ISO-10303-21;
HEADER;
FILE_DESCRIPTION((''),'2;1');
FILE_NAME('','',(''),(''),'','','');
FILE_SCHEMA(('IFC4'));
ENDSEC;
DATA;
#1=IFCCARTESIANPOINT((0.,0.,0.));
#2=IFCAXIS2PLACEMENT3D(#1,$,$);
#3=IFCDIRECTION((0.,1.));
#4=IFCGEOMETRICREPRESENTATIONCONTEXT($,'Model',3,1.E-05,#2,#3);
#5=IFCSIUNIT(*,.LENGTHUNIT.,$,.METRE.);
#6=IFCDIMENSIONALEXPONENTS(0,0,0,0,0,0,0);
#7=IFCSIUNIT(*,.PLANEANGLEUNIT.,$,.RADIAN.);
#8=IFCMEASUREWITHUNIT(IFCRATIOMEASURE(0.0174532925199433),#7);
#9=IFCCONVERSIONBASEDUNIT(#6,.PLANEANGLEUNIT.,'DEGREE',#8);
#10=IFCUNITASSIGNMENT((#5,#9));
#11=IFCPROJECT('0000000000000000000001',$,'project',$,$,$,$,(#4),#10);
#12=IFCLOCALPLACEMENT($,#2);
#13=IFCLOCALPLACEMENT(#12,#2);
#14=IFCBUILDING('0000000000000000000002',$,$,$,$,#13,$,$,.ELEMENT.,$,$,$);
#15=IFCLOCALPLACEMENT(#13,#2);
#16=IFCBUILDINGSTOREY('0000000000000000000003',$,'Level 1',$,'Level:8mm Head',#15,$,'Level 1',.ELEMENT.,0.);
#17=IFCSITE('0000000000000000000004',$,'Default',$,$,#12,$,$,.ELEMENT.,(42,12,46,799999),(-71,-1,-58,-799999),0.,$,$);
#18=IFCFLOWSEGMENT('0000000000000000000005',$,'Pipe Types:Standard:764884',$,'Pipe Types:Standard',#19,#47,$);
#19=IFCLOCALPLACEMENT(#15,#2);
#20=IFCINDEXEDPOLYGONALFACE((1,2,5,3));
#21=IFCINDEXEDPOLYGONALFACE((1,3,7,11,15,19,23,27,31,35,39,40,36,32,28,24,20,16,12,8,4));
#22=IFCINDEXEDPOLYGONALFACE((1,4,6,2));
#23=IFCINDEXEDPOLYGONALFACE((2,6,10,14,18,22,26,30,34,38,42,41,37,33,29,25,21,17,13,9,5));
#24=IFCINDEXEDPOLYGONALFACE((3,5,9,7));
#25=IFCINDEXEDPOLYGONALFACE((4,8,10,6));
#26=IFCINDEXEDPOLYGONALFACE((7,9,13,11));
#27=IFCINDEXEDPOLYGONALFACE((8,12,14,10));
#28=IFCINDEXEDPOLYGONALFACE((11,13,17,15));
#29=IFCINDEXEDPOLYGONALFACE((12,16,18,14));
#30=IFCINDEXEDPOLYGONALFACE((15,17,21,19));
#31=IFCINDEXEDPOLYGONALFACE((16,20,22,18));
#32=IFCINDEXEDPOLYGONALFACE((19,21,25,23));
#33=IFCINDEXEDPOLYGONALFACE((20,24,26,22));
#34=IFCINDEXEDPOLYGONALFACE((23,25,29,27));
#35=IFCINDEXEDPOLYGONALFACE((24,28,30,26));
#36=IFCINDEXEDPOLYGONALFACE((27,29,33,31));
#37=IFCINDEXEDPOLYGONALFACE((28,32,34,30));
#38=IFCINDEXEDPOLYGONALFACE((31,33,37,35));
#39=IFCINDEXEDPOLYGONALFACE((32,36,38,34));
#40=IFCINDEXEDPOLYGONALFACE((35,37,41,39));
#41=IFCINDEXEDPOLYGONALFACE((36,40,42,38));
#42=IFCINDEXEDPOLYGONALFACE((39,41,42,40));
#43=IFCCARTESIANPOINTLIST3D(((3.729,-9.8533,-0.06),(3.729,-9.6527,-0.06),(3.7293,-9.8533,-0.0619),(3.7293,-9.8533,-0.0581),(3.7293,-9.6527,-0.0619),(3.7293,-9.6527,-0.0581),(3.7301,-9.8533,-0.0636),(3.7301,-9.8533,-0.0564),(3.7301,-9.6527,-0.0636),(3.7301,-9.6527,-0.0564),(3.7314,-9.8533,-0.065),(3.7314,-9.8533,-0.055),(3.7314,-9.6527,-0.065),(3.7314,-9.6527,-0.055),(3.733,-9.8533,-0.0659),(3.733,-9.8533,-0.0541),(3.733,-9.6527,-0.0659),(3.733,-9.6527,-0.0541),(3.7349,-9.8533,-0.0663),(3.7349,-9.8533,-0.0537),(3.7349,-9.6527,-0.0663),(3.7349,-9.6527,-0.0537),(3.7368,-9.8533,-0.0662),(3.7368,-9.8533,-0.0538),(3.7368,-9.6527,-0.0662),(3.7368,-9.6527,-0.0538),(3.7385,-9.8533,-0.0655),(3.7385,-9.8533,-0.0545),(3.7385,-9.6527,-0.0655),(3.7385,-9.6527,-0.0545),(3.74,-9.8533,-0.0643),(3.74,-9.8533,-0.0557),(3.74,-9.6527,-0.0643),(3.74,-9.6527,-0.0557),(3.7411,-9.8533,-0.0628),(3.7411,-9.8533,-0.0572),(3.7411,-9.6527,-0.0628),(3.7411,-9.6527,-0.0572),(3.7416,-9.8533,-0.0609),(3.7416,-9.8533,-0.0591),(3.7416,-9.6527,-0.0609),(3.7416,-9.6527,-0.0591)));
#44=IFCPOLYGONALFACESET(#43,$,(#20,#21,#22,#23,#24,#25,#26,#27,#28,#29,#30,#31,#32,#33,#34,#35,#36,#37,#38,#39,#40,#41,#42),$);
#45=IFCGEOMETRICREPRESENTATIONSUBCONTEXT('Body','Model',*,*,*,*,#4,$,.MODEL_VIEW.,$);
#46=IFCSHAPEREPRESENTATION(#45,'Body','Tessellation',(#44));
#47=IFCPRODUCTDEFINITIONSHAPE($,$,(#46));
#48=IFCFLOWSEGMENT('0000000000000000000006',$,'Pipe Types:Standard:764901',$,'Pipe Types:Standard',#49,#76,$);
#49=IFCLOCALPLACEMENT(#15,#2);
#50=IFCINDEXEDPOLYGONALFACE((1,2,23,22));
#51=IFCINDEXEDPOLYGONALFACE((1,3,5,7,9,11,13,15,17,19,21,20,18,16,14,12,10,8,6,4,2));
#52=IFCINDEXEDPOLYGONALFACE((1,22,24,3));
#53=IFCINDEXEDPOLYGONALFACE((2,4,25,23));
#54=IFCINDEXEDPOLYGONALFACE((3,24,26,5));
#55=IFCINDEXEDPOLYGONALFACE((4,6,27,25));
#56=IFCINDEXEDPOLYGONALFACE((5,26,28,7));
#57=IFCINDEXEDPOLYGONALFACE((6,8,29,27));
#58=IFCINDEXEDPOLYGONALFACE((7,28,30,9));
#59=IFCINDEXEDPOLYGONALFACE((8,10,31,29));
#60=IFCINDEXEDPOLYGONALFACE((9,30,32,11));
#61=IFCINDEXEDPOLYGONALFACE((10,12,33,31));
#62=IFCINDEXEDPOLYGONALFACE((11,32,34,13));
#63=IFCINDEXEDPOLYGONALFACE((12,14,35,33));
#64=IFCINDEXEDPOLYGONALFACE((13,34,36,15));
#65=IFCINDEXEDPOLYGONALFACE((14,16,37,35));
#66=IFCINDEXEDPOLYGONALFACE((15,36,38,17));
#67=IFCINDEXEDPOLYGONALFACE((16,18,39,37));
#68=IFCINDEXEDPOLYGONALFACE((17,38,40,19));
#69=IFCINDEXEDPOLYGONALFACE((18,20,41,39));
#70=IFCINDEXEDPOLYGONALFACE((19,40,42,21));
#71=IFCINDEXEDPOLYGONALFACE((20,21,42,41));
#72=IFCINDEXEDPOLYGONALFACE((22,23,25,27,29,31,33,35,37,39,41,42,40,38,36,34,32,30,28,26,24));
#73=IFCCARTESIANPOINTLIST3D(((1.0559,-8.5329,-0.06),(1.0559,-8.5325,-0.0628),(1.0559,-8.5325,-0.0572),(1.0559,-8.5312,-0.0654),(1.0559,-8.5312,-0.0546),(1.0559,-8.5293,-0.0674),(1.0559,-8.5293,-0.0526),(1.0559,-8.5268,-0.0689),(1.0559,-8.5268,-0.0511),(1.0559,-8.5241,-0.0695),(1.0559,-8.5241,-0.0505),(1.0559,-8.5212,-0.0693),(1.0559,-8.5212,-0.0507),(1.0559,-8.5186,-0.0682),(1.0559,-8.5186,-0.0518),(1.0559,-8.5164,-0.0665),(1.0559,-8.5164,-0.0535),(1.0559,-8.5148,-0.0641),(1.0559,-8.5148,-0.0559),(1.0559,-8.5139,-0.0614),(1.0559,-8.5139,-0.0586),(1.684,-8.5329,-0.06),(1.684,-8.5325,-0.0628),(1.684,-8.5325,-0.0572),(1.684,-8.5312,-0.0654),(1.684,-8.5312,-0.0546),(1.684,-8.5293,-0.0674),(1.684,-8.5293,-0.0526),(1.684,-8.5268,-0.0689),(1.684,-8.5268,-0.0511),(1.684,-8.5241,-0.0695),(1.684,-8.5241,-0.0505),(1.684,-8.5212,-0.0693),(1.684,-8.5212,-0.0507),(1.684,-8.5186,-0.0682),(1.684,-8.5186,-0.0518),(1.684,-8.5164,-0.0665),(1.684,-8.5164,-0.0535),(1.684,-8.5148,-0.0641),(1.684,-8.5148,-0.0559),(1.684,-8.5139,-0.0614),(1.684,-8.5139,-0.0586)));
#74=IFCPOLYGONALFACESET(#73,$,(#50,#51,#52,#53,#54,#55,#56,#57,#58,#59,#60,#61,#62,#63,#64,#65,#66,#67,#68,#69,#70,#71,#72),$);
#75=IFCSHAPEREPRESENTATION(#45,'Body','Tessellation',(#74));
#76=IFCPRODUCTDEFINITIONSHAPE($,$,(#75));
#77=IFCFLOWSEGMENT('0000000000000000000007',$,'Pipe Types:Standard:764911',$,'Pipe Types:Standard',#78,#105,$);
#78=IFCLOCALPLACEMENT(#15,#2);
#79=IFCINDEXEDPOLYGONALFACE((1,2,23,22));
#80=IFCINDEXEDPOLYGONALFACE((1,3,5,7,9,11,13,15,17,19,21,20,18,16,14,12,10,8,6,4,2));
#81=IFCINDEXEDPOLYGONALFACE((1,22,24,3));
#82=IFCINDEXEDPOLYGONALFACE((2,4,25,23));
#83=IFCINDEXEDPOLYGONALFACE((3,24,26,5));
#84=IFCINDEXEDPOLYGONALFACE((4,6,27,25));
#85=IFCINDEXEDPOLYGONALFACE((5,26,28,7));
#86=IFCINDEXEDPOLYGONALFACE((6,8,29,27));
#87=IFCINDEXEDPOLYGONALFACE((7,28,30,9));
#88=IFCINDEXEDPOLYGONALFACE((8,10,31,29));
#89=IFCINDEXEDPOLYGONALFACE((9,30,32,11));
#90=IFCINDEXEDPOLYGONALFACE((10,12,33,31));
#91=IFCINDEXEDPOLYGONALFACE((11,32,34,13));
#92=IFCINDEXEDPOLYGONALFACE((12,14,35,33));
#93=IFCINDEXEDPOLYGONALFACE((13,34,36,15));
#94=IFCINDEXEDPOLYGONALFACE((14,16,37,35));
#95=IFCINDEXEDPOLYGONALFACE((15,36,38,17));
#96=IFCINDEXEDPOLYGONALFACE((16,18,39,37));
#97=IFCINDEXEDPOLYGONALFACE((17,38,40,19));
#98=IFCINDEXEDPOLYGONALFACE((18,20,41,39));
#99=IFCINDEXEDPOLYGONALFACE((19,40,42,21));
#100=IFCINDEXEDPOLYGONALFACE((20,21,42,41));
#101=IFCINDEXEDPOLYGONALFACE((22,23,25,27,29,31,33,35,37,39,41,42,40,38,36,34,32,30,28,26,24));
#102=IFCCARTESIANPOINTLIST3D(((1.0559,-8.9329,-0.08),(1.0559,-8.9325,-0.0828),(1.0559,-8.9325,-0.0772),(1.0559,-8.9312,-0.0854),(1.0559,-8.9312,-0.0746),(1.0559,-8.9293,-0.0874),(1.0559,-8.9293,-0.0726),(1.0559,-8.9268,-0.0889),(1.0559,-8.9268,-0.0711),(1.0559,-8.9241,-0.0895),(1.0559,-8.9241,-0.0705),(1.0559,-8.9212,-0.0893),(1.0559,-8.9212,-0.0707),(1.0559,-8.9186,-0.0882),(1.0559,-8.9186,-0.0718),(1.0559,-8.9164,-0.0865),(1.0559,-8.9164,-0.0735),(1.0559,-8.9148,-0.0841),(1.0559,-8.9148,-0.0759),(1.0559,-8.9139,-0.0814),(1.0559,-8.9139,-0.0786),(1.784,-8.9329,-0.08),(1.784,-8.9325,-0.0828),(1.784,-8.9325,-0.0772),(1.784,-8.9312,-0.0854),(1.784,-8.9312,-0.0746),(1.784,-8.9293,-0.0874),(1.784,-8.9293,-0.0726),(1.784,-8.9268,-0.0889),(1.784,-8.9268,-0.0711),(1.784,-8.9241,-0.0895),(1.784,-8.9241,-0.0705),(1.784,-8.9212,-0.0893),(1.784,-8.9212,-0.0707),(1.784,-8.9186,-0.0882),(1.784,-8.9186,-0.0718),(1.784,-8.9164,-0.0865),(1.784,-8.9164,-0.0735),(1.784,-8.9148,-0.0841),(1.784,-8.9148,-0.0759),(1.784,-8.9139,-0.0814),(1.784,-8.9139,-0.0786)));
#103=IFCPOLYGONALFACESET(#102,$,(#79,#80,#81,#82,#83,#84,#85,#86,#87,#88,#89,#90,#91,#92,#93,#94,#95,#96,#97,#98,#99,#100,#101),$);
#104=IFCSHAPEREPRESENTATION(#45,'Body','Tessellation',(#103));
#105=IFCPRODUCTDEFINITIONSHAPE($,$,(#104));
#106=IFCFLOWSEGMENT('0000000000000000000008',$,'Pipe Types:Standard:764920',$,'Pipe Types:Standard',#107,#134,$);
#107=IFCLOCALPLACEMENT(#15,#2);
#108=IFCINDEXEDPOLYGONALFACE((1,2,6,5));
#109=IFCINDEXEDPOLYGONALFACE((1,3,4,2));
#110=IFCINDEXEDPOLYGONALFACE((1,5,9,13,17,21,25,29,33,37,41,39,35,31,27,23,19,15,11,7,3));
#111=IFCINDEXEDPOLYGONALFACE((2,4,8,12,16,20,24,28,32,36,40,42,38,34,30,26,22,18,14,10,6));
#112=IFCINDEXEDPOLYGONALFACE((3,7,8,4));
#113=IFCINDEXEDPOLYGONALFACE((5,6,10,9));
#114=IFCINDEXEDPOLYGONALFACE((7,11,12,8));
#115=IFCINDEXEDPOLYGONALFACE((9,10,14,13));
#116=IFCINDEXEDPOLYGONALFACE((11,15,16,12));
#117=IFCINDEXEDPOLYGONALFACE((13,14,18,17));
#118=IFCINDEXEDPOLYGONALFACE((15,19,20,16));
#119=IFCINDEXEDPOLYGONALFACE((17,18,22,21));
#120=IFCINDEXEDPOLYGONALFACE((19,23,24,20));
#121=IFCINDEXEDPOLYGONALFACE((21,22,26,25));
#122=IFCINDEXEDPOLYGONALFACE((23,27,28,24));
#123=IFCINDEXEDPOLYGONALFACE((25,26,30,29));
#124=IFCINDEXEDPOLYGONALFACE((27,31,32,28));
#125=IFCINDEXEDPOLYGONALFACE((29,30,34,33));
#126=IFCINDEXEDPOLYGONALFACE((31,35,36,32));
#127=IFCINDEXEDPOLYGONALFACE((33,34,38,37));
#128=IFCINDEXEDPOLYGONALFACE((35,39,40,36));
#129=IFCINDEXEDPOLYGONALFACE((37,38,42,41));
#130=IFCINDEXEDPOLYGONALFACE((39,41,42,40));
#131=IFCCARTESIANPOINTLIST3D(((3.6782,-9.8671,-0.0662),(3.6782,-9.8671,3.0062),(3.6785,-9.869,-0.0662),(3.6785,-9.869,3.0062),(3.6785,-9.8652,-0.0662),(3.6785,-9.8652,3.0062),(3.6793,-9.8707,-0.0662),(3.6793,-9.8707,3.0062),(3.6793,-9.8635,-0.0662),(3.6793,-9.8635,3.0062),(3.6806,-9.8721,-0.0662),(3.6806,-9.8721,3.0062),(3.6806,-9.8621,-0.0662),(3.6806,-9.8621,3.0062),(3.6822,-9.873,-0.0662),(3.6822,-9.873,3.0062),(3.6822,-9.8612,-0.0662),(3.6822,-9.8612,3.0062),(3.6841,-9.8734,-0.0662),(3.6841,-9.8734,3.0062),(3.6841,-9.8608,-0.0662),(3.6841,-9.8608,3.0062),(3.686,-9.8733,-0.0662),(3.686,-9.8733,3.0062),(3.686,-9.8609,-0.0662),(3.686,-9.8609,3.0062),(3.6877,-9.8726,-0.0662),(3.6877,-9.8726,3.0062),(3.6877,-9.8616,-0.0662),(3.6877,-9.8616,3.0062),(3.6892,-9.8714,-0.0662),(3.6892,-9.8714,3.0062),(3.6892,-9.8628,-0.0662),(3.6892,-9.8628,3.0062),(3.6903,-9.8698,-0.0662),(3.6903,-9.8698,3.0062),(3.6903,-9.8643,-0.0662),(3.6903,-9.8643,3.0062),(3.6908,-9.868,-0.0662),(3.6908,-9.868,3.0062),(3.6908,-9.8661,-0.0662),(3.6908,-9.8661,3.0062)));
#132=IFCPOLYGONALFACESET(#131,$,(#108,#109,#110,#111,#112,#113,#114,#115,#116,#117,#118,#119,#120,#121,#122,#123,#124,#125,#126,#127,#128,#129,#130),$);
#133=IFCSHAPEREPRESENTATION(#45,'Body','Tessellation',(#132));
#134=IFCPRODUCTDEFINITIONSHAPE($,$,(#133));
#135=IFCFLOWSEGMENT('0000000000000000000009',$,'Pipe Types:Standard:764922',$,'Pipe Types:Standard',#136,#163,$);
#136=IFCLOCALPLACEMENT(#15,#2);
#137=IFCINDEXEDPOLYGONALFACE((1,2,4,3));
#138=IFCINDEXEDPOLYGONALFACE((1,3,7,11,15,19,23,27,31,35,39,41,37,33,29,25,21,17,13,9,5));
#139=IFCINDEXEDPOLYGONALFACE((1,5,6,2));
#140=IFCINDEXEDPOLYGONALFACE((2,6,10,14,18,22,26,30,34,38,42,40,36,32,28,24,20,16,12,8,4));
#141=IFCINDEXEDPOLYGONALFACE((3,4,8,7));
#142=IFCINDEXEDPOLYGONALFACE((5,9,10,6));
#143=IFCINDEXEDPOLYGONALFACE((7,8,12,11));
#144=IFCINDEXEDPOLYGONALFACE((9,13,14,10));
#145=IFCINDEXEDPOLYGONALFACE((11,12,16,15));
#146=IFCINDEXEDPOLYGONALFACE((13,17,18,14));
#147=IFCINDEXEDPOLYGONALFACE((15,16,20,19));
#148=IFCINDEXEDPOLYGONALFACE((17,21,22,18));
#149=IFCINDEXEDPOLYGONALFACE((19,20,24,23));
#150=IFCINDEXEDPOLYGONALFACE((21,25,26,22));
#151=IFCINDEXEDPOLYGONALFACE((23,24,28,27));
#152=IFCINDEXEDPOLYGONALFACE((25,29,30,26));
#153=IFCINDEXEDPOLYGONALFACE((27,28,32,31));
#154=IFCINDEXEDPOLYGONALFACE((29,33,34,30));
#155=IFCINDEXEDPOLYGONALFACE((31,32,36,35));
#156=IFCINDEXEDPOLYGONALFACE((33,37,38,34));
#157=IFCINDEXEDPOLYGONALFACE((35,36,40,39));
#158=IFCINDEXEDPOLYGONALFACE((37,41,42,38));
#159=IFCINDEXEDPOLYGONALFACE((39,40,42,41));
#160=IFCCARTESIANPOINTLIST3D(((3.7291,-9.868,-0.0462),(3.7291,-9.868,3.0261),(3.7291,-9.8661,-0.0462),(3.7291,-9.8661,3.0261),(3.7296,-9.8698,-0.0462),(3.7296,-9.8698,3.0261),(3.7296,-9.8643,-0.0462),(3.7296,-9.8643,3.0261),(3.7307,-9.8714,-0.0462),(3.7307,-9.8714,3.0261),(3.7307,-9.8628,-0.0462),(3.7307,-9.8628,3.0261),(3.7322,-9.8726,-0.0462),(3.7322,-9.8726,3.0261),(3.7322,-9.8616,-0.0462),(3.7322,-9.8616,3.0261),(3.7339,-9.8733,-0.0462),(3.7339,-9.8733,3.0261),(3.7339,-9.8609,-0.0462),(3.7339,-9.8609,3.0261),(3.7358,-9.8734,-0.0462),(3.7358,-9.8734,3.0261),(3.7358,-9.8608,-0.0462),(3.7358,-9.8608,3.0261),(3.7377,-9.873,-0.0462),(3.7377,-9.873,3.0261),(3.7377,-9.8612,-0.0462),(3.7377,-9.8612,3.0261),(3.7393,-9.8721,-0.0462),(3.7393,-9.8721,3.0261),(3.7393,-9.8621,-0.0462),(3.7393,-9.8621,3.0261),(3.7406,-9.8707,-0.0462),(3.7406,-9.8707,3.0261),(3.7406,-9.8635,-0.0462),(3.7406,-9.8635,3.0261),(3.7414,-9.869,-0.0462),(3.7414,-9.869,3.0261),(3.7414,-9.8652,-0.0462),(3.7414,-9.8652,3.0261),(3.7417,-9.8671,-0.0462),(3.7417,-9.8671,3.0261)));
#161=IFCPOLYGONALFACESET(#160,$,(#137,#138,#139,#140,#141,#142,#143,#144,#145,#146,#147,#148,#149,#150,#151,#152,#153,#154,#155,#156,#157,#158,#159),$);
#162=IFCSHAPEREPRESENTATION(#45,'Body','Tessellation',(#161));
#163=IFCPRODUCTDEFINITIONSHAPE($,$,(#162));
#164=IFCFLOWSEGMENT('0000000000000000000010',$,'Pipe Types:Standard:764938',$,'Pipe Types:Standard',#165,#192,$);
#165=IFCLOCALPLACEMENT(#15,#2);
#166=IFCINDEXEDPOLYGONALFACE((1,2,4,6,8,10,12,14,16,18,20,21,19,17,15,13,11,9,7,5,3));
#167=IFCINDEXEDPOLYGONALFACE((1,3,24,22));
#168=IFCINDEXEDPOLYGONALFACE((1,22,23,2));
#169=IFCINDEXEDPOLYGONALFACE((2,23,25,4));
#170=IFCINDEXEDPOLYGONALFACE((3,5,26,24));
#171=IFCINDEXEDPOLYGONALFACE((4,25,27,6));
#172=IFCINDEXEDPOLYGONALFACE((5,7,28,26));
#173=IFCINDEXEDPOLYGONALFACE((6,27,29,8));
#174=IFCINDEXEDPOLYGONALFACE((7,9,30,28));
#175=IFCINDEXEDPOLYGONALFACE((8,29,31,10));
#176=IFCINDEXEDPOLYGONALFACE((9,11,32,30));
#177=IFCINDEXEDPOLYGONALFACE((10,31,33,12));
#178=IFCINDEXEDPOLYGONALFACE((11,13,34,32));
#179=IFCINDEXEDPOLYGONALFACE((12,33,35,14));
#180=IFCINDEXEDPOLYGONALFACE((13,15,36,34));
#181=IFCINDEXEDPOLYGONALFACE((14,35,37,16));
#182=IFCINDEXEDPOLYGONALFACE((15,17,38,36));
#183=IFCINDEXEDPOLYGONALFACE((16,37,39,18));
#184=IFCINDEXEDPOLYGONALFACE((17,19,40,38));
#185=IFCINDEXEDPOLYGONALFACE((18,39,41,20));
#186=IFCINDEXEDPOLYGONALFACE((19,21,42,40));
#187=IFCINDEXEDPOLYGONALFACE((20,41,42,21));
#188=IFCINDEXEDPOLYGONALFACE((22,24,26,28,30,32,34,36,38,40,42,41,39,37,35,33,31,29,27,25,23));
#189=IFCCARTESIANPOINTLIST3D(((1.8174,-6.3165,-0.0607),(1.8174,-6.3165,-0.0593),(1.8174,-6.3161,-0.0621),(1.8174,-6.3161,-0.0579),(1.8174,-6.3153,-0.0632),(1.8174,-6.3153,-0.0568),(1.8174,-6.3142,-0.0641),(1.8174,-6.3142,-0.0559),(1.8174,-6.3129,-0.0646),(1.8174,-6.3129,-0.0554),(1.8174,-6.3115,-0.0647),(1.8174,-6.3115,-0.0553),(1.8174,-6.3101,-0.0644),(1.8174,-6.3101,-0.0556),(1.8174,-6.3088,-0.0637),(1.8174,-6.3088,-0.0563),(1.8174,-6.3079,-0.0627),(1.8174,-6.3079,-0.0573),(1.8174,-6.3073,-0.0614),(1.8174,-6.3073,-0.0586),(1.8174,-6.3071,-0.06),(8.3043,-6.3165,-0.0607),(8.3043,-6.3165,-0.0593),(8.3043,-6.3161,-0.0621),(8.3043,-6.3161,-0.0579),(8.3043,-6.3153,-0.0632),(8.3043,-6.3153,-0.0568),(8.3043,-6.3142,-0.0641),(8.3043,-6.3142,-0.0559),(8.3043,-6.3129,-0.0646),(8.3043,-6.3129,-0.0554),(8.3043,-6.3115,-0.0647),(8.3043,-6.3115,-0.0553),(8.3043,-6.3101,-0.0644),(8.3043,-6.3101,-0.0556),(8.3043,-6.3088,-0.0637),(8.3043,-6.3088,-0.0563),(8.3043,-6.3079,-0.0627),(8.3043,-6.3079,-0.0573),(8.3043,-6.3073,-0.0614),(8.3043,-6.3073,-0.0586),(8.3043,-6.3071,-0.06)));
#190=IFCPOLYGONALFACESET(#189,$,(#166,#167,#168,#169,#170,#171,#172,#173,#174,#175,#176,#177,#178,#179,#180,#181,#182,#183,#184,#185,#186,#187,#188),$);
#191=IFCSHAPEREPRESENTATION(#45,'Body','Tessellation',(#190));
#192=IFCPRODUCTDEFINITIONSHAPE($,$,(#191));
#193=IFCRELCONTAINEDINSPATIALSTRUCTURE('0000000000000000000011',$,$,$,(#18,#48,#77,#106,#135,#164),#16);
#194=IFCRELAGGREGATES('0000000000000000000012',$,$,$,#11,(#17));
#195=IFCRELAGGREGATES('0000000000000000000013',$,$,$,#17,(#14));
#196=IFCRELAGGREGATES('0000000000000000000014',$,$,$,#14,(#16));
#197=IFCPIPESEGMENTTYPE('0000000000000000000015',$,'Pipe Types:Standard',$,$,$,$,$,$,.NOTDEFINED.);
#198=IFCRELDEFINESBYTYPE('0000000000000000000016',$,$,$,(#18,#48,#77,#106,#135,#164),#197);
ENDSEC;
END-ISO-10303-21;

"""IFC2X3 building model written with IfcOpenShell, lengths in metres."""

from ifc_helpers import new_model, entity, si_unit, converted_unit, direction, frame, frame_2d, origin, origin_2d_with_axis, place, context, subcontext, project, spatial, circle, extrude, type_object, element, save


model = new_model("IFC2X3")

# Units and contexts
model_context = context("Model", 3, precision=1e-05, world=origin(), true_north=direction((0.0, 1.0)))
body_context = subcontext(model_context, "Body", "Model", "MODEL_VIEW")
ifc_project = project(units=[si_unit("LENGTHUNIT", "METRE"), converted_unit("PLANEANGLEUNIT", "DEGREE", entity("IfcRatioMeasure", 0.0174532925199433), si_unit("PLANEANGLEUNIT", "RADIAN"), dimensions=[0, 0, 0, 0, 0, 0, 0])], contexts=[model_context])

# Site, building, storey
site_placement = place(None, origin())
site = spatial("IfcSite", under=ifc_project, at=site_placement, Name="Default", CompositionType="ELEMENT", RefLatitude=(42, 12, 46, 799999), RefLongitude=(-71, -1, -58, -799999), RefElevation=0.0)
building_placement = place(site_placement, origin())
building = spatial("IfcBuilding", under=site, at=building_placement, CompositionType="ELEMENT")
storey_placement = place(building_placement, origin())
storey = spatial("IfcBuildingStorey", under=building, at=storey_placement, Name="Level 1", ObjectType="Level:8mm Head", LongName="Level 1", CompositionType="ELEMENT", Elevation=0.0)

# Flow segments
pipe_segment_type = type_object("IfcPipeSegmentType", Name="Pipe Types:Standard", PredefinedType="NOTDEFINED")
flow_segment_1_placement = place(storey_placement, origin())
element("IfcFlowSegment", 1, at=flow_segment_1_placement, inside=storey, type_object=pipe_segment_type, Name="Pipe Types:Standard:764884", ObjectType="Pipe Types:Standard", context=body_context, shape_type="SweptSolid", body=[
    extrude(circle(Radius=0.0063, at=frame_2d((0.0, 0.0), x_axis=(1.0, 0.0))), frame((3.7353, -9.8533, -0.06), z_axis=(0.0, 1.0, 0.0), x_axis=(-1.0, 0.0, 0.0)), (0.0, 0.0, 1.0), 0.2006),
])
flow_segment_2_placement = place(storey_placement, origin())
element("IfcFlowSegment", 2, at=flow_segment_2_placement, inside=storey, type_object=pipe_segment_type, Name="Pipe Types:Standard:764901", ObjectType="Pipe Types:Standard", context=body_context, shape_type="SweptSolid", body=[
    extrude(circle(Radius=0.0095, at=frame_2d((0.0, 0.0), x_axis=(1.0, 0.0))), frame((1.0559, -8.5234, -0.06), z_axis=(1.0, 0.0, 0.0), x_axis=(0.0, -1.0, 0.0)), (0.0, 0.0, 1.0), 0.6281),
])
flow_segment_3_placement = place(storey_placement, origin())
element("IfcFlowSegment", 3, at=flow_segment_3_placement, inside=storey, type_object=pipe_segment_type, Name="Pipe Types:Standard:764911", ObjectType="Pipe Types:Standard", context=body_context, shape_type="SweptSolid", body=[
    extrude(circle(Radius=0.0095, at=origin_2d_with_axis()), frame((1.0559, -8.9234, -0.08), z_axis=(1.0, 0.0, 0.0), x_axis=(0.0, -1.0, 0.0)), (0.0, 0.0, 1.0), 0.7281),
])
flow_segment_4_placement = place(storey_placement, origin())
element("IfcFlowSegment", 4, at=flow_segment_4_placement, inside=storey, type_object=pipe_segment_type, Name="Pipe Types:Standard:764920", ObjectType="Pipe Types:Standard", context=body_context, shape_type="SweptSolid", body=[
    extrude(circle(Radius=0.0063, at=origin_2d_with_axis()), frame((3.6845, -9.8671, -0.0662), z_axis=(0.0, 0.0, 1.0), x_axis=(-1.0, 0.0, 0.0)), (0.0, 0.0, 1.0), 3.0724),
])
flow_segment_5_placement = place(storey_placement, origin())
element("IfcFlowSegment", 5, at=flow_segment_5_placement, inside=storey, type_object=pipe_segment_type, Name="Pipe Types:Standard:764922", ObjectType="Pipe Types:Standard", context=body_context, shape_type="SweptSolid", body=[
    extrude(circle(Radius=0.0063, at=origin_2d_with_axis()), frame((3.7353, -9.8671, -0.0462)), (0.0, 0.0, 1.0), 3.0723),
])
flow_segment_6_placement = place(storey_placement, origin())
element("IfcFlowSegment", 6, at=flow_segment_6_placement, inside=storey, type_object=pipe_segment_type, Name="Pipe Types:Standard:764938", ObjectType="Pipe Types:Standard", context=body_context, shape_type="SweptSolid", body=[
    extrude(circle(Radius=0.0048, at=frame_2d((0.0, 0.0), x_axis=(1.0, 0.0))), frame((1.8174, -6.3118, -0.06), z_axis=(1.0, 0.0, 0.0), x_axis=(0.0, 1.0, 0.0)), (0.0, 0.0, 1.0), 6.4868),
])

save(model, "model.ifc")
